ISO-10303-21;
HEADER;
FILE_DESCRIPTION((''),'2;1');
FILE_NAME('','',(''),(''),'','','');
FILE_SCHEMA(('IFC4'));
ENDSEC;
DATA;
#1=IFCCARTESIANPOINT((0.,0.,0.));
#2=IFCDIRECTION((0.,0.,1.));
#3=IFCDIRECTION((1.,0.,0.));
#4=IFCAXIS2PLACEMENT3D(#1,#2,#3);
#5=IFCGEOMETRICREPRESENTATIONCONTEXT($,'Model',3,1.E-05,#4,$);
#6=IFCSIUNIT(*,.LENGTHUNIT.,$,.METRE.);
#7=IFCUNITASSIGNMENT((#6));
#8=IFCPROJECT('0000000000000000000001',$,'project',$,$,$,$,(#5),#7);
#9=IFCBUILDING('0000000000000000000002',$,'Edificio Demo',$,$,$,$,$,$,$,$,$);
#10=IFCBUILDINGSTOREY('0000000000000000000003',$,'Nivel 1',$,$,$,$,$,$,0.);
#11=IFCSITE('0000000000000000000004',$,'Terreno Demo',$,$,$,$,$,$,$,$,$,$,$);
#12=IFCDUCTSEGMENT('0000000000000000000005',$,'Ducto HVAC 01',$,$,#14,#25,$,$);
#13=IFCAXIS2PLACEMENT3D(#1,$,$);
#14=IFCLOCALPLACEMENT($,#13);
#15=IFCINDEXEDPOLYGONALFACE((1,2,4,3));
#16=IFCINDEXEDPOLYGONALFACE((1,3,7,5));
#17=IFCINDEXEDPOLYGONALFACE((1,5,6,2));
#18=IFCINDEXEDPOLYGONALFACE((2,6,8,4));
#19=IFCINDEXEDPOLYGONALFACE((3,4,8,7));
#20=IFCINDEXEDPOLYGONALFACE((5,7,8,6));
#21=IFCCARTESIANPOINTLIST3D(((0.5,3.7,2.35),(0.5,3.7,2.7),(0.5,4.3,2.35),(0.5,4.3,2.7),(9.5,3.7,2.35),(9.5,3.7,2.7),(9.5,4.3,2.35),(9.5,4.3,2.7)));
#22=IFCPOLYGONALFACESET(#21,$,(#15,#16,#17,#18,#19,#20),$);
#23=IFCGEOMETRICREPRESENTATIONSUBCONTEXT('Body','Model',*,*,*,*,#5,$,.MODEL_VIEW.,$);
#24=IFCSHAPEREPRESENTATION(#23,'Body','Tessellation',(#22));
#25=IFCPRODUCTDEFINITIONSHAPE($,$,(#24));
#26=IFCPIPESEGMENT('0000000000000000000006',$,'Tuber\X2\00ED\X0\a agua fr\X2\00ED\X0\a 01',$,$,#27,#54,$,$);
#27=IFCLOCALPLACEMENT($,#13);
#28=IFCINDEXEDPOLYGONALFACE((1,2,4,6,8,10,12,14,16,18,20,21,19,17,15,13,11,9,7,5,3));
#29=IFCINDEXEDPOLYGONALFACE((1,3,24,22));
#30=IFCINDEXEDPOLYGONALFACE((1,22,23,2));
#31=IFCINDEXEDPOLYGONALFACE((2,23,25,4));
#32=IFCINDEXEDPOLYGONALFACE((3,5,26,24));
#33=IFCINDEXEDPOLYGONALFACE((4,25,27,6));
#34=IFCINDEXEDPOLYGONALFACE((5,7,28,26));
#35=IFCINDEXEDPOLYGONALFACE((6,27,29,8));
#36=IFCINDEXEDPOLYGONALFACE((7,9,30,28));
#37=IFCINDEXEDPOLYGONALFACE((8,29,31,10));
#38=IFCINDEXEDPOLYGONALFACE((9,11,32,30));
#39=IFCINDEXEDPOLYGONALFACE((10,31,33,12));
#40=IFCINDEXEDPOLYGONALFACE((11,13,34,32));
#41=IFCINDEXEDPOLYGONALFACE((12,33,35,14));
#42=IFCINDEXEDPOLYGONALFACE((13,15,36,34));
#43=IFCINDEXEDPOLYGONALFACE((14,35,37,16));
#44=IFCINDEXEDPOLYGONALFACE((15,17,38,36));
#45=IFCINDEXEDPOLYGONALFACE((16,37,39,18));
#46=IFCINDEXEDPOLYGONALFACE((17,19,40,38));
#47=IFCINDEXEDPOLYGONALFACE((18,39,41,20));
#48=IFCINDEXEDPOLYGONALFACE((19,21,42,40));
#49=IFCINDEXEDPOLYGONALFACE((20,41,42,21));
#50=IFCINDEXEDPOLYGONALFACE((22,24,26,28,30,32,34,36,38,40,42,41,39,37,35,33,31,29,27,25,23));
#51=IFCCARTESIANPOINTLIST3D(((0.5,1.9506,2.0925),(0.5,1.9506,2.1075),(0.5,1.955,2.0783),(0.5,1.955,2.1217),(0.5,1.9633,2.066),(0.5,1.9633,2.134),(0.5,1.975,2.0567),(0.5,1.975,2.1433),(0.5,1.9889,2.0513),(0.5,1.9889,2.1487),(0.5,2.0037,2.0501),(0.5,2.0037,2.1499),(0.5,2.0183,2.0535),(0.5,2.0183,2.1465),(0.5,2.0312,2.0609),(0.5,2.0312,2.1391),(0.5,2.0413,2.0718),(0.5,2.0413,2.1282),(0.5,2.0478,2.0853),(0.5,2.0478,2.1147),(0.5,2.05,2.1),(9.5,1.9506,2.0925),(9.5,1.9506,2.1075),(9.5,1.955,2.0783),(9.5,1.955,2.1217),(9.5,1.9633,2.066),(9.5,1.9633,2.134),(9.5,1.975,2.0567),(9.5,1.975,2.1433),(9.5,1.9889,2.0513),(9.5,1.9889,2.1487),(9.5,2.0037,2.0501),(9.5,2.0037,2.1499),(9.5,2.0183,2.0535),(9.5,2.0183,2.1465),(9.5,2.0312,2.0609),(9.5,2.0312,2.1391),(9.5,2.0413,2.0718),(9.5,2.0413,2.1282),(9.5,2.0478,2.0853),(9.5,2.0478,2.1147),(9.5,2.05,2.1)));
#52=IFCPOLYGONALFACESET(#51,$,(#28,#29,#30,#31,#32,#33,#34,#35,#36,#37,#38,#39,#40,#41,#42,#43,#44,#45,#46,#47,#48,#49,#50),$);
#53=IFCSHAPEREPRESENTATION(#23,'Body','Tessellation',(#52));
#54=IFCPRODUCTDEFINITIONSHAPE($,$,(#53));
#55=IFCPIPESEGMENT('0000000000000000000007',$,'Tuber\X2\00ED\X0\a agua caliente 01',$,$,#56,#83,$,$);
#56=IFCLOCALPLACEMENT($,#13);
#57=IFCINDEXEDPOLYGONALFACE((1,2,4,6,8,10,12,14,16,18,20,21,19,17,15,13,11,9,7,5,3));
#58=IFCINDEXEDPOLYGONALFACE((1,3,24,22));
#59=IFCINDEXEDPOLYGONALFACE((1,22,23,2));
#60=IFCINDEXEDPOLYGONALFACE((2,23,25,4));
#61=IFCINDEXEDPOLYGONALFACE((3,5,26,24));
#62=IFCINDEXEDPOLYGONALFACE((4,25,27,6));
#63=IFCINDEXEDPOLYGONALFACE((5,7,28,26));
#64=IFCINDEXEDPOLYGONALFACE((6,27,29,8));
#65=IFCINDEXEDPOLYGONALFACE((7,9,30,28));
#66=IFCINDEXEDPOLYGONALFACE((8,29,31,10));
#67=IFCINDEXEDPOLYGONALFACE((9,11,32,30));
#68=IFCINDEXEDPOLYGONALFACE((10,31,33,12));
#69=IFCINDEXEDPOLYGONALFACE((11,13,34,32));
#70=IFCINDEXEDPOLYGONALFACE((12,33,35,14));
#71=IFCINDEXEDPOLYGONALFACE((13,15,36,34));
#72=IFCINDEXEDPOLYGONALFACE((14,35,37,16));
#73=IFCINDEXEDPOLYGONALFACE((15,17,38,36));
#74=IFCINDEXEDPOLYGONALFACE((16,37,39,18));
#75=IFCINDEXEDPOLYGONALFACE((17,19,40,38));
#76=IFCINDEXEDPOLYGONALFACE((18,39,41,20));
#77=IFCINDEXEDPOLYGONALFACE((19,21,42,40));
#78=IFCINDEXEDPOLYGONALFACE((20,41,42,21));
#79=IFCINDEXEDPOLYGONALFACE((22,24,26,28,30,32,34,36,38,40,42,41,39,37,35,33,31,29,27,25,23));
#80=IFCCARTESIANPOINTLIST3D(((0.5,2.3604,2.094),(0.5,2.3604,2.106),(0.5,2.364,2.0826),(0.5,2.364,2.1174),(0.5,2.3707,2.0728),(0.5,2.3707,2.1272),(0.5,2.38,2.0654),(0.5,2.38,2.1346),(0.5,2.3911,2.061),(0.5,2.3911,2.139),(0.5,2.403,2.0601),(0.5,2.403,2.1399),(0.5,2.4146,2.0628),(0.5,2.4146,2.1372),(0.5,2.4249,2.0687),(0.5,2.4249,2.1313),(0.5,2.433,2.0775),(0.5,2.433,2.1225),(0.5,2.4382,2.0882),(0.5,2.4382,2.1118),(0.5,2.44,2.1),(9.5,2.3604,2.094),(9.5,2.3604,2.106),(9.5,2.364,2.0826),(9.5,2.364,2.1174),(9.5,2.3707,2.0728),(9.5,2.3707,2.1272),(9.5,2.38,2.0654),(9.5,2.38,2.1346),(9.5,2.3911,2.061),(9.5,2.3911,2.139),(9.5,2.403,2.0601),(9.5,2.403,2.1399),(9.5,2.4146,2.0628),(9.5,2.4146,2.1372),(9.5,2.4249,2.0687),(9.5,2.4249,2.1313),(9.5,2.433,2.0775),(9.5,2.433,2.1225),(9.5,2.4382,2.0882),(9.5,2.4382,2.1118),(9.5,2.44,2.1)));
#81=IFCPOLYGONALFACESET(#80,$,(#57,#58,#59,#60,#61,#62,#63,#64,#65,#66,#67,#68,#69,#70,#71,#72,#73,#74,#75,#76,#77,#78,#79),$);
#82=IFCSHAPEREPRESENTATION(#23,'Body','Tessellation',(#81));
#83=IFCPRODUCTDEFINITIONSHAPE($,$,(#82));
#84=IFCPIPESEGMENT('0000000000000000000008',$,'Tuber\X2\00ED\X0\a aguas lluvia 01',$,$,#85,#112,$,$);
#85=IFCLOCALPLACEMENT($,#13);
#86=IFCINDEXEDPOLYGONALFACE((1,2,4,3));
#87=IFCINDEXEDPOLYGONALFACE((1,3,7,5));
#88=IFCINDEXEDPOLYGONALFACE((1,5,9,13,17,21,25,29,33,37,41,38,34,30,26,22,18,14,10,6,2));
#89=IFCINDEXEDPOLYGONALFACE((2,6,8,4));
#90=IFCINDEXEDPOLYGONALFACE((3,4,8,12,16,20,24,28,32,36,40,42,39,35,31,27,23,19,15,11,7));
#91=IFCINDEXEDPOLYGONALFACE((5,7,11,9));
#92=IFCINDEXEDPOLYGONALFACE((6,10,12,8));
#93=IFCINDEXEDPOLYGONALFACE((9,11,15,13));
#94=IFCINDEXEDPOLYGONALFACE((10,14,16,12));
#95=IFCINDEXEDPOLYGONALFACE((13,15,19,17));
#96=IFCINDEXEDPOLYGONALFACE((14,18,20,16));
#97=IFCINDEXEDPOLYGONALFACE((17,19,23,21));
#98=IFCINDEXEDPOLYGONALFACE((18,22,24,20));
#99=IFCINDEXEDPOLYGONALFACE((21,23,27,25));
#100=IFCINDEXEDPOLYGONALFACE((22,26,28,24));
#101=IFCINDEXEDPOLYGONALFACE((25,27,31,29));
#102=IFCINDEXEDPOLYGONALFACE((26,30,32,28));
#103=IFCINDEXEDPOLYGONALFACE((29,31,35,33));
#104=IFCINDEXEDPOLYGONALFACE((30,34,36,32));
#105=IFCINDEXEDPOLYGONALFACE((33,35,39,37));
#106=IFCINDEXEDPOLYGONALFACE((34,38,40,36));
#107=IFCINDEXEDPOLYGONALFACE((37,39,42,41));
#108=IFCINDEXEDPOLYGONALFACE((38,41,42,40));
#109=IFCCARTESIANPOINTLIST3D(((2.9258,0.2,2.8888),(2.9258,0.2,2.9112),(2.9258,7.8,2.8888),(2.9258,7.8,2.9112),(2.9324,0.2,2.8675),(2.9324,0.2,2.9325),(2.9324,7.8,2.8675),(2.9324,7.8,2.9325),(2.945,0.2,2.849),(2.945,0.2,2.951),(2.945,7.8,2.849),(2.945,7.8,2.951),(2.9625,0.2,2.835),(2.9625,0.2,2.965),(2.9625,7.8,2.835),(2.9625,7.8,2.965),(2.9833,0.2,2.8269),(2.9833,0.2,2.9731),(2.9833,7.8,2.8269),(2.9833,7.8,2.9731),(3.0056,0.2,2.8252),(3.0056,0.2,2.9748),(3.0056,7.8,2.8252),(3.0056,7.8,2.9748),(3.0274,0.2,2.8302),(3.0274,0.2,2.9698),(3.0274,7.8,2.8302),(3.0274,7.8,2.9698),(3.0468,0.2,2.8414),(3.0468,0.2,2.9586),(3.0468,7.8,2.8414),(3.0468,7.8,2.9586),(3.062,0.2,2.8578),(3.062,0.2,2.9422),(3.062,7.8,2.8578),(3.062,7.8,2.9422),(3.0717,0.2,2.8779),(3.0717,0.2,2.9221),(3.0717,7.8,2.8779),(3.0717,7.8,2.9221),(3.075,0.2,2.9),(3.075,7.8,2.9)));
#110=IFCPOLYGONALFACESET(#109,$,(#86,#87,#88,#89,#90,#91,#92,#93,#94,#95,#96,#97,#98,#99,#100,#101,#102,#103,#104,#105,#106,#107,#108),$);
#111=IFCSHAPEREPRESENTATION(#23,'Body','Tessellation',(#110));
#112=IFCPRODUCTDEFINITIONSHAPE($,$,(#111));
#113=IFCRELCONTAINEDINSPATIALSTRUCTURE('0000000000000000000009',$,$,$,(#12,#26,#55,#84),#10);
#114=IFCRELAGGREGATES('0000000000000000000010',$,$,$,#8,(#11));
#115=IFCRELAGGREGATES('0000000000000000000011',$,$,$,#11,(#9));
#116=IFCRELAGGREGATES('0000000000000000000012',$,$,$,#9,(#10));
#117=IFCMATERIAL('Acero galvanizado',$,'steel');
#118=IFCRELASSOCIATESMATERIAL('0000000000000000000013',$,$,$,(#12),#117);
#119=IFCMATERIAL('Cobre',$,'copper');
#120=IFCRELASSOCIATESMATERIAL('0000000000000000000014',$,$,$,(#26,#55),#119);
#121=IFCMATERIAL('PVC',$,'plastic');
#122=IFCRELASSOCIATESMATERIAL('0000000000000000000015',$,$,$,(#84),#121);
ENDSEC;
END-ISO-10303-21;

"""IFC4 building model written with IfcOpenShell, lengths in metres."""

from ifc_helpers import new_model, si_unit, frame, frame_2d, origin_with_axes, place, context, subcontext, project, spatial, rectangle, circle, extrude, material, element, save


model = new_model("IFC4")

# Units and contexts
model_context = context("Model", 3, precision=1e-05, world=origin_with_axes())
body_context = subcontext(model_context, "Body", "Model", "MODEL_VIEW")
ifc_project = project(units=[si_unit("LENGTHUNIT", "METRE")], contexts=[model_context])

# Site, building, storey
site = spatial("IfcSite", under=ifc_project, Name="Terreno Demo")
building = spatial("IfcBuilding", under=site, Name="Edificio Demo")
storey = spatial("IfcBuildingStorey", under=building, Name="Nivel 1", Elevation=0.0)

# Duct segment
ifc_material_1 = material(Name="Acero galvanizado", Category="steel")
duct_segment_placement = place(None, frame((0.5, 3.7, 2.35), z_axis=(0.0, 0.0, 1.0), x_axis=(1.0, 0.0, 0.0)))
element("IfcDuctSegment", 1, at=duct_segment_placement, inside=storey, material=ifc_material_1, Name="Ducto HVAC 01", context=body_context, shape_type="SweptSolid", body=[
    extrude(rectangle(XDim=9.0, YDim=0.6, at=frame_2d((4.5, 0.3))), origin_with_axes(), (0.0, 0.0, 1.0), 0.35),
])

# Pipe segments
ifc_material_2 = material(Name="Cobre", Category="copper")
pipe_segment_1_placement = place(None, frame((0.5, 2.0, 2.1), z_axis=(0.0, 0.0, 1.0), x_axis=(1.0, 0.0, 0.0)))
element("IfcPipeSegment", 2, at=pipe_segment_1_placement, inside=storey, material=ifc_material_2, Name="Tubería agua fría 01", context=body_context, shape_type="SweptSolid", body=[
    extrude(circle(Radius=0.05), frame((0.0, 0.0, 0.0), z_axis=(1.0, 0.0, 0.0), x_axis=(0.0, 1.0, 0.0)), (0.0, 0.0, 1.0), 9.0),
])
pipe_segment_2_placement = place(None, frame((0.5, 2.4, 2.1), z_axis=(0.0, 0.0, 1.0), x_axis=(1.0, 0.0, 0.0)))
element("IfcPipeSegment", 3, at=pipe_segment_2_placement, inside=storey, material=ifc_material_2, Name="Tubería agua caliente 01", context=body_context, shape_type="SweptSolid", body=[
    extrude(circle(Radius=0.04), frame((0.0, 0.0, 0.0), z_axis=(1.0, 0.0, 0.0), x_axis=(0.0, 1.0, 0.0)), (0.0, 0.0, 1.0), 9.0),
])
ifc_material_3 = material(Name="PVC", Category="plastic")
pipe_segment_3_placement = place(None, frame((3.0, 0.2, 2.9), z_axis=(0.0, 0.0, 1.0), x_axis=(1.0, 0.0, 0.0)))
element("IfcPipeSegment", 4, at=pipe_segment_3_placement, inside=storey, material=ifc_material_3, Name="Tubería aguas lluvia 01", context=body_context, shape_type="SweptSolid", body=[
    extrude(circle(Radius=0.075), frame((0.0, 0.0, 0.0), z_axis=(0.0, 1.0, 0.0), x_axis=(1.0, 0.0, 0.0)), (0.0, 0.0, 1.0), 7.6),
])

save(model, "model.ifc")
